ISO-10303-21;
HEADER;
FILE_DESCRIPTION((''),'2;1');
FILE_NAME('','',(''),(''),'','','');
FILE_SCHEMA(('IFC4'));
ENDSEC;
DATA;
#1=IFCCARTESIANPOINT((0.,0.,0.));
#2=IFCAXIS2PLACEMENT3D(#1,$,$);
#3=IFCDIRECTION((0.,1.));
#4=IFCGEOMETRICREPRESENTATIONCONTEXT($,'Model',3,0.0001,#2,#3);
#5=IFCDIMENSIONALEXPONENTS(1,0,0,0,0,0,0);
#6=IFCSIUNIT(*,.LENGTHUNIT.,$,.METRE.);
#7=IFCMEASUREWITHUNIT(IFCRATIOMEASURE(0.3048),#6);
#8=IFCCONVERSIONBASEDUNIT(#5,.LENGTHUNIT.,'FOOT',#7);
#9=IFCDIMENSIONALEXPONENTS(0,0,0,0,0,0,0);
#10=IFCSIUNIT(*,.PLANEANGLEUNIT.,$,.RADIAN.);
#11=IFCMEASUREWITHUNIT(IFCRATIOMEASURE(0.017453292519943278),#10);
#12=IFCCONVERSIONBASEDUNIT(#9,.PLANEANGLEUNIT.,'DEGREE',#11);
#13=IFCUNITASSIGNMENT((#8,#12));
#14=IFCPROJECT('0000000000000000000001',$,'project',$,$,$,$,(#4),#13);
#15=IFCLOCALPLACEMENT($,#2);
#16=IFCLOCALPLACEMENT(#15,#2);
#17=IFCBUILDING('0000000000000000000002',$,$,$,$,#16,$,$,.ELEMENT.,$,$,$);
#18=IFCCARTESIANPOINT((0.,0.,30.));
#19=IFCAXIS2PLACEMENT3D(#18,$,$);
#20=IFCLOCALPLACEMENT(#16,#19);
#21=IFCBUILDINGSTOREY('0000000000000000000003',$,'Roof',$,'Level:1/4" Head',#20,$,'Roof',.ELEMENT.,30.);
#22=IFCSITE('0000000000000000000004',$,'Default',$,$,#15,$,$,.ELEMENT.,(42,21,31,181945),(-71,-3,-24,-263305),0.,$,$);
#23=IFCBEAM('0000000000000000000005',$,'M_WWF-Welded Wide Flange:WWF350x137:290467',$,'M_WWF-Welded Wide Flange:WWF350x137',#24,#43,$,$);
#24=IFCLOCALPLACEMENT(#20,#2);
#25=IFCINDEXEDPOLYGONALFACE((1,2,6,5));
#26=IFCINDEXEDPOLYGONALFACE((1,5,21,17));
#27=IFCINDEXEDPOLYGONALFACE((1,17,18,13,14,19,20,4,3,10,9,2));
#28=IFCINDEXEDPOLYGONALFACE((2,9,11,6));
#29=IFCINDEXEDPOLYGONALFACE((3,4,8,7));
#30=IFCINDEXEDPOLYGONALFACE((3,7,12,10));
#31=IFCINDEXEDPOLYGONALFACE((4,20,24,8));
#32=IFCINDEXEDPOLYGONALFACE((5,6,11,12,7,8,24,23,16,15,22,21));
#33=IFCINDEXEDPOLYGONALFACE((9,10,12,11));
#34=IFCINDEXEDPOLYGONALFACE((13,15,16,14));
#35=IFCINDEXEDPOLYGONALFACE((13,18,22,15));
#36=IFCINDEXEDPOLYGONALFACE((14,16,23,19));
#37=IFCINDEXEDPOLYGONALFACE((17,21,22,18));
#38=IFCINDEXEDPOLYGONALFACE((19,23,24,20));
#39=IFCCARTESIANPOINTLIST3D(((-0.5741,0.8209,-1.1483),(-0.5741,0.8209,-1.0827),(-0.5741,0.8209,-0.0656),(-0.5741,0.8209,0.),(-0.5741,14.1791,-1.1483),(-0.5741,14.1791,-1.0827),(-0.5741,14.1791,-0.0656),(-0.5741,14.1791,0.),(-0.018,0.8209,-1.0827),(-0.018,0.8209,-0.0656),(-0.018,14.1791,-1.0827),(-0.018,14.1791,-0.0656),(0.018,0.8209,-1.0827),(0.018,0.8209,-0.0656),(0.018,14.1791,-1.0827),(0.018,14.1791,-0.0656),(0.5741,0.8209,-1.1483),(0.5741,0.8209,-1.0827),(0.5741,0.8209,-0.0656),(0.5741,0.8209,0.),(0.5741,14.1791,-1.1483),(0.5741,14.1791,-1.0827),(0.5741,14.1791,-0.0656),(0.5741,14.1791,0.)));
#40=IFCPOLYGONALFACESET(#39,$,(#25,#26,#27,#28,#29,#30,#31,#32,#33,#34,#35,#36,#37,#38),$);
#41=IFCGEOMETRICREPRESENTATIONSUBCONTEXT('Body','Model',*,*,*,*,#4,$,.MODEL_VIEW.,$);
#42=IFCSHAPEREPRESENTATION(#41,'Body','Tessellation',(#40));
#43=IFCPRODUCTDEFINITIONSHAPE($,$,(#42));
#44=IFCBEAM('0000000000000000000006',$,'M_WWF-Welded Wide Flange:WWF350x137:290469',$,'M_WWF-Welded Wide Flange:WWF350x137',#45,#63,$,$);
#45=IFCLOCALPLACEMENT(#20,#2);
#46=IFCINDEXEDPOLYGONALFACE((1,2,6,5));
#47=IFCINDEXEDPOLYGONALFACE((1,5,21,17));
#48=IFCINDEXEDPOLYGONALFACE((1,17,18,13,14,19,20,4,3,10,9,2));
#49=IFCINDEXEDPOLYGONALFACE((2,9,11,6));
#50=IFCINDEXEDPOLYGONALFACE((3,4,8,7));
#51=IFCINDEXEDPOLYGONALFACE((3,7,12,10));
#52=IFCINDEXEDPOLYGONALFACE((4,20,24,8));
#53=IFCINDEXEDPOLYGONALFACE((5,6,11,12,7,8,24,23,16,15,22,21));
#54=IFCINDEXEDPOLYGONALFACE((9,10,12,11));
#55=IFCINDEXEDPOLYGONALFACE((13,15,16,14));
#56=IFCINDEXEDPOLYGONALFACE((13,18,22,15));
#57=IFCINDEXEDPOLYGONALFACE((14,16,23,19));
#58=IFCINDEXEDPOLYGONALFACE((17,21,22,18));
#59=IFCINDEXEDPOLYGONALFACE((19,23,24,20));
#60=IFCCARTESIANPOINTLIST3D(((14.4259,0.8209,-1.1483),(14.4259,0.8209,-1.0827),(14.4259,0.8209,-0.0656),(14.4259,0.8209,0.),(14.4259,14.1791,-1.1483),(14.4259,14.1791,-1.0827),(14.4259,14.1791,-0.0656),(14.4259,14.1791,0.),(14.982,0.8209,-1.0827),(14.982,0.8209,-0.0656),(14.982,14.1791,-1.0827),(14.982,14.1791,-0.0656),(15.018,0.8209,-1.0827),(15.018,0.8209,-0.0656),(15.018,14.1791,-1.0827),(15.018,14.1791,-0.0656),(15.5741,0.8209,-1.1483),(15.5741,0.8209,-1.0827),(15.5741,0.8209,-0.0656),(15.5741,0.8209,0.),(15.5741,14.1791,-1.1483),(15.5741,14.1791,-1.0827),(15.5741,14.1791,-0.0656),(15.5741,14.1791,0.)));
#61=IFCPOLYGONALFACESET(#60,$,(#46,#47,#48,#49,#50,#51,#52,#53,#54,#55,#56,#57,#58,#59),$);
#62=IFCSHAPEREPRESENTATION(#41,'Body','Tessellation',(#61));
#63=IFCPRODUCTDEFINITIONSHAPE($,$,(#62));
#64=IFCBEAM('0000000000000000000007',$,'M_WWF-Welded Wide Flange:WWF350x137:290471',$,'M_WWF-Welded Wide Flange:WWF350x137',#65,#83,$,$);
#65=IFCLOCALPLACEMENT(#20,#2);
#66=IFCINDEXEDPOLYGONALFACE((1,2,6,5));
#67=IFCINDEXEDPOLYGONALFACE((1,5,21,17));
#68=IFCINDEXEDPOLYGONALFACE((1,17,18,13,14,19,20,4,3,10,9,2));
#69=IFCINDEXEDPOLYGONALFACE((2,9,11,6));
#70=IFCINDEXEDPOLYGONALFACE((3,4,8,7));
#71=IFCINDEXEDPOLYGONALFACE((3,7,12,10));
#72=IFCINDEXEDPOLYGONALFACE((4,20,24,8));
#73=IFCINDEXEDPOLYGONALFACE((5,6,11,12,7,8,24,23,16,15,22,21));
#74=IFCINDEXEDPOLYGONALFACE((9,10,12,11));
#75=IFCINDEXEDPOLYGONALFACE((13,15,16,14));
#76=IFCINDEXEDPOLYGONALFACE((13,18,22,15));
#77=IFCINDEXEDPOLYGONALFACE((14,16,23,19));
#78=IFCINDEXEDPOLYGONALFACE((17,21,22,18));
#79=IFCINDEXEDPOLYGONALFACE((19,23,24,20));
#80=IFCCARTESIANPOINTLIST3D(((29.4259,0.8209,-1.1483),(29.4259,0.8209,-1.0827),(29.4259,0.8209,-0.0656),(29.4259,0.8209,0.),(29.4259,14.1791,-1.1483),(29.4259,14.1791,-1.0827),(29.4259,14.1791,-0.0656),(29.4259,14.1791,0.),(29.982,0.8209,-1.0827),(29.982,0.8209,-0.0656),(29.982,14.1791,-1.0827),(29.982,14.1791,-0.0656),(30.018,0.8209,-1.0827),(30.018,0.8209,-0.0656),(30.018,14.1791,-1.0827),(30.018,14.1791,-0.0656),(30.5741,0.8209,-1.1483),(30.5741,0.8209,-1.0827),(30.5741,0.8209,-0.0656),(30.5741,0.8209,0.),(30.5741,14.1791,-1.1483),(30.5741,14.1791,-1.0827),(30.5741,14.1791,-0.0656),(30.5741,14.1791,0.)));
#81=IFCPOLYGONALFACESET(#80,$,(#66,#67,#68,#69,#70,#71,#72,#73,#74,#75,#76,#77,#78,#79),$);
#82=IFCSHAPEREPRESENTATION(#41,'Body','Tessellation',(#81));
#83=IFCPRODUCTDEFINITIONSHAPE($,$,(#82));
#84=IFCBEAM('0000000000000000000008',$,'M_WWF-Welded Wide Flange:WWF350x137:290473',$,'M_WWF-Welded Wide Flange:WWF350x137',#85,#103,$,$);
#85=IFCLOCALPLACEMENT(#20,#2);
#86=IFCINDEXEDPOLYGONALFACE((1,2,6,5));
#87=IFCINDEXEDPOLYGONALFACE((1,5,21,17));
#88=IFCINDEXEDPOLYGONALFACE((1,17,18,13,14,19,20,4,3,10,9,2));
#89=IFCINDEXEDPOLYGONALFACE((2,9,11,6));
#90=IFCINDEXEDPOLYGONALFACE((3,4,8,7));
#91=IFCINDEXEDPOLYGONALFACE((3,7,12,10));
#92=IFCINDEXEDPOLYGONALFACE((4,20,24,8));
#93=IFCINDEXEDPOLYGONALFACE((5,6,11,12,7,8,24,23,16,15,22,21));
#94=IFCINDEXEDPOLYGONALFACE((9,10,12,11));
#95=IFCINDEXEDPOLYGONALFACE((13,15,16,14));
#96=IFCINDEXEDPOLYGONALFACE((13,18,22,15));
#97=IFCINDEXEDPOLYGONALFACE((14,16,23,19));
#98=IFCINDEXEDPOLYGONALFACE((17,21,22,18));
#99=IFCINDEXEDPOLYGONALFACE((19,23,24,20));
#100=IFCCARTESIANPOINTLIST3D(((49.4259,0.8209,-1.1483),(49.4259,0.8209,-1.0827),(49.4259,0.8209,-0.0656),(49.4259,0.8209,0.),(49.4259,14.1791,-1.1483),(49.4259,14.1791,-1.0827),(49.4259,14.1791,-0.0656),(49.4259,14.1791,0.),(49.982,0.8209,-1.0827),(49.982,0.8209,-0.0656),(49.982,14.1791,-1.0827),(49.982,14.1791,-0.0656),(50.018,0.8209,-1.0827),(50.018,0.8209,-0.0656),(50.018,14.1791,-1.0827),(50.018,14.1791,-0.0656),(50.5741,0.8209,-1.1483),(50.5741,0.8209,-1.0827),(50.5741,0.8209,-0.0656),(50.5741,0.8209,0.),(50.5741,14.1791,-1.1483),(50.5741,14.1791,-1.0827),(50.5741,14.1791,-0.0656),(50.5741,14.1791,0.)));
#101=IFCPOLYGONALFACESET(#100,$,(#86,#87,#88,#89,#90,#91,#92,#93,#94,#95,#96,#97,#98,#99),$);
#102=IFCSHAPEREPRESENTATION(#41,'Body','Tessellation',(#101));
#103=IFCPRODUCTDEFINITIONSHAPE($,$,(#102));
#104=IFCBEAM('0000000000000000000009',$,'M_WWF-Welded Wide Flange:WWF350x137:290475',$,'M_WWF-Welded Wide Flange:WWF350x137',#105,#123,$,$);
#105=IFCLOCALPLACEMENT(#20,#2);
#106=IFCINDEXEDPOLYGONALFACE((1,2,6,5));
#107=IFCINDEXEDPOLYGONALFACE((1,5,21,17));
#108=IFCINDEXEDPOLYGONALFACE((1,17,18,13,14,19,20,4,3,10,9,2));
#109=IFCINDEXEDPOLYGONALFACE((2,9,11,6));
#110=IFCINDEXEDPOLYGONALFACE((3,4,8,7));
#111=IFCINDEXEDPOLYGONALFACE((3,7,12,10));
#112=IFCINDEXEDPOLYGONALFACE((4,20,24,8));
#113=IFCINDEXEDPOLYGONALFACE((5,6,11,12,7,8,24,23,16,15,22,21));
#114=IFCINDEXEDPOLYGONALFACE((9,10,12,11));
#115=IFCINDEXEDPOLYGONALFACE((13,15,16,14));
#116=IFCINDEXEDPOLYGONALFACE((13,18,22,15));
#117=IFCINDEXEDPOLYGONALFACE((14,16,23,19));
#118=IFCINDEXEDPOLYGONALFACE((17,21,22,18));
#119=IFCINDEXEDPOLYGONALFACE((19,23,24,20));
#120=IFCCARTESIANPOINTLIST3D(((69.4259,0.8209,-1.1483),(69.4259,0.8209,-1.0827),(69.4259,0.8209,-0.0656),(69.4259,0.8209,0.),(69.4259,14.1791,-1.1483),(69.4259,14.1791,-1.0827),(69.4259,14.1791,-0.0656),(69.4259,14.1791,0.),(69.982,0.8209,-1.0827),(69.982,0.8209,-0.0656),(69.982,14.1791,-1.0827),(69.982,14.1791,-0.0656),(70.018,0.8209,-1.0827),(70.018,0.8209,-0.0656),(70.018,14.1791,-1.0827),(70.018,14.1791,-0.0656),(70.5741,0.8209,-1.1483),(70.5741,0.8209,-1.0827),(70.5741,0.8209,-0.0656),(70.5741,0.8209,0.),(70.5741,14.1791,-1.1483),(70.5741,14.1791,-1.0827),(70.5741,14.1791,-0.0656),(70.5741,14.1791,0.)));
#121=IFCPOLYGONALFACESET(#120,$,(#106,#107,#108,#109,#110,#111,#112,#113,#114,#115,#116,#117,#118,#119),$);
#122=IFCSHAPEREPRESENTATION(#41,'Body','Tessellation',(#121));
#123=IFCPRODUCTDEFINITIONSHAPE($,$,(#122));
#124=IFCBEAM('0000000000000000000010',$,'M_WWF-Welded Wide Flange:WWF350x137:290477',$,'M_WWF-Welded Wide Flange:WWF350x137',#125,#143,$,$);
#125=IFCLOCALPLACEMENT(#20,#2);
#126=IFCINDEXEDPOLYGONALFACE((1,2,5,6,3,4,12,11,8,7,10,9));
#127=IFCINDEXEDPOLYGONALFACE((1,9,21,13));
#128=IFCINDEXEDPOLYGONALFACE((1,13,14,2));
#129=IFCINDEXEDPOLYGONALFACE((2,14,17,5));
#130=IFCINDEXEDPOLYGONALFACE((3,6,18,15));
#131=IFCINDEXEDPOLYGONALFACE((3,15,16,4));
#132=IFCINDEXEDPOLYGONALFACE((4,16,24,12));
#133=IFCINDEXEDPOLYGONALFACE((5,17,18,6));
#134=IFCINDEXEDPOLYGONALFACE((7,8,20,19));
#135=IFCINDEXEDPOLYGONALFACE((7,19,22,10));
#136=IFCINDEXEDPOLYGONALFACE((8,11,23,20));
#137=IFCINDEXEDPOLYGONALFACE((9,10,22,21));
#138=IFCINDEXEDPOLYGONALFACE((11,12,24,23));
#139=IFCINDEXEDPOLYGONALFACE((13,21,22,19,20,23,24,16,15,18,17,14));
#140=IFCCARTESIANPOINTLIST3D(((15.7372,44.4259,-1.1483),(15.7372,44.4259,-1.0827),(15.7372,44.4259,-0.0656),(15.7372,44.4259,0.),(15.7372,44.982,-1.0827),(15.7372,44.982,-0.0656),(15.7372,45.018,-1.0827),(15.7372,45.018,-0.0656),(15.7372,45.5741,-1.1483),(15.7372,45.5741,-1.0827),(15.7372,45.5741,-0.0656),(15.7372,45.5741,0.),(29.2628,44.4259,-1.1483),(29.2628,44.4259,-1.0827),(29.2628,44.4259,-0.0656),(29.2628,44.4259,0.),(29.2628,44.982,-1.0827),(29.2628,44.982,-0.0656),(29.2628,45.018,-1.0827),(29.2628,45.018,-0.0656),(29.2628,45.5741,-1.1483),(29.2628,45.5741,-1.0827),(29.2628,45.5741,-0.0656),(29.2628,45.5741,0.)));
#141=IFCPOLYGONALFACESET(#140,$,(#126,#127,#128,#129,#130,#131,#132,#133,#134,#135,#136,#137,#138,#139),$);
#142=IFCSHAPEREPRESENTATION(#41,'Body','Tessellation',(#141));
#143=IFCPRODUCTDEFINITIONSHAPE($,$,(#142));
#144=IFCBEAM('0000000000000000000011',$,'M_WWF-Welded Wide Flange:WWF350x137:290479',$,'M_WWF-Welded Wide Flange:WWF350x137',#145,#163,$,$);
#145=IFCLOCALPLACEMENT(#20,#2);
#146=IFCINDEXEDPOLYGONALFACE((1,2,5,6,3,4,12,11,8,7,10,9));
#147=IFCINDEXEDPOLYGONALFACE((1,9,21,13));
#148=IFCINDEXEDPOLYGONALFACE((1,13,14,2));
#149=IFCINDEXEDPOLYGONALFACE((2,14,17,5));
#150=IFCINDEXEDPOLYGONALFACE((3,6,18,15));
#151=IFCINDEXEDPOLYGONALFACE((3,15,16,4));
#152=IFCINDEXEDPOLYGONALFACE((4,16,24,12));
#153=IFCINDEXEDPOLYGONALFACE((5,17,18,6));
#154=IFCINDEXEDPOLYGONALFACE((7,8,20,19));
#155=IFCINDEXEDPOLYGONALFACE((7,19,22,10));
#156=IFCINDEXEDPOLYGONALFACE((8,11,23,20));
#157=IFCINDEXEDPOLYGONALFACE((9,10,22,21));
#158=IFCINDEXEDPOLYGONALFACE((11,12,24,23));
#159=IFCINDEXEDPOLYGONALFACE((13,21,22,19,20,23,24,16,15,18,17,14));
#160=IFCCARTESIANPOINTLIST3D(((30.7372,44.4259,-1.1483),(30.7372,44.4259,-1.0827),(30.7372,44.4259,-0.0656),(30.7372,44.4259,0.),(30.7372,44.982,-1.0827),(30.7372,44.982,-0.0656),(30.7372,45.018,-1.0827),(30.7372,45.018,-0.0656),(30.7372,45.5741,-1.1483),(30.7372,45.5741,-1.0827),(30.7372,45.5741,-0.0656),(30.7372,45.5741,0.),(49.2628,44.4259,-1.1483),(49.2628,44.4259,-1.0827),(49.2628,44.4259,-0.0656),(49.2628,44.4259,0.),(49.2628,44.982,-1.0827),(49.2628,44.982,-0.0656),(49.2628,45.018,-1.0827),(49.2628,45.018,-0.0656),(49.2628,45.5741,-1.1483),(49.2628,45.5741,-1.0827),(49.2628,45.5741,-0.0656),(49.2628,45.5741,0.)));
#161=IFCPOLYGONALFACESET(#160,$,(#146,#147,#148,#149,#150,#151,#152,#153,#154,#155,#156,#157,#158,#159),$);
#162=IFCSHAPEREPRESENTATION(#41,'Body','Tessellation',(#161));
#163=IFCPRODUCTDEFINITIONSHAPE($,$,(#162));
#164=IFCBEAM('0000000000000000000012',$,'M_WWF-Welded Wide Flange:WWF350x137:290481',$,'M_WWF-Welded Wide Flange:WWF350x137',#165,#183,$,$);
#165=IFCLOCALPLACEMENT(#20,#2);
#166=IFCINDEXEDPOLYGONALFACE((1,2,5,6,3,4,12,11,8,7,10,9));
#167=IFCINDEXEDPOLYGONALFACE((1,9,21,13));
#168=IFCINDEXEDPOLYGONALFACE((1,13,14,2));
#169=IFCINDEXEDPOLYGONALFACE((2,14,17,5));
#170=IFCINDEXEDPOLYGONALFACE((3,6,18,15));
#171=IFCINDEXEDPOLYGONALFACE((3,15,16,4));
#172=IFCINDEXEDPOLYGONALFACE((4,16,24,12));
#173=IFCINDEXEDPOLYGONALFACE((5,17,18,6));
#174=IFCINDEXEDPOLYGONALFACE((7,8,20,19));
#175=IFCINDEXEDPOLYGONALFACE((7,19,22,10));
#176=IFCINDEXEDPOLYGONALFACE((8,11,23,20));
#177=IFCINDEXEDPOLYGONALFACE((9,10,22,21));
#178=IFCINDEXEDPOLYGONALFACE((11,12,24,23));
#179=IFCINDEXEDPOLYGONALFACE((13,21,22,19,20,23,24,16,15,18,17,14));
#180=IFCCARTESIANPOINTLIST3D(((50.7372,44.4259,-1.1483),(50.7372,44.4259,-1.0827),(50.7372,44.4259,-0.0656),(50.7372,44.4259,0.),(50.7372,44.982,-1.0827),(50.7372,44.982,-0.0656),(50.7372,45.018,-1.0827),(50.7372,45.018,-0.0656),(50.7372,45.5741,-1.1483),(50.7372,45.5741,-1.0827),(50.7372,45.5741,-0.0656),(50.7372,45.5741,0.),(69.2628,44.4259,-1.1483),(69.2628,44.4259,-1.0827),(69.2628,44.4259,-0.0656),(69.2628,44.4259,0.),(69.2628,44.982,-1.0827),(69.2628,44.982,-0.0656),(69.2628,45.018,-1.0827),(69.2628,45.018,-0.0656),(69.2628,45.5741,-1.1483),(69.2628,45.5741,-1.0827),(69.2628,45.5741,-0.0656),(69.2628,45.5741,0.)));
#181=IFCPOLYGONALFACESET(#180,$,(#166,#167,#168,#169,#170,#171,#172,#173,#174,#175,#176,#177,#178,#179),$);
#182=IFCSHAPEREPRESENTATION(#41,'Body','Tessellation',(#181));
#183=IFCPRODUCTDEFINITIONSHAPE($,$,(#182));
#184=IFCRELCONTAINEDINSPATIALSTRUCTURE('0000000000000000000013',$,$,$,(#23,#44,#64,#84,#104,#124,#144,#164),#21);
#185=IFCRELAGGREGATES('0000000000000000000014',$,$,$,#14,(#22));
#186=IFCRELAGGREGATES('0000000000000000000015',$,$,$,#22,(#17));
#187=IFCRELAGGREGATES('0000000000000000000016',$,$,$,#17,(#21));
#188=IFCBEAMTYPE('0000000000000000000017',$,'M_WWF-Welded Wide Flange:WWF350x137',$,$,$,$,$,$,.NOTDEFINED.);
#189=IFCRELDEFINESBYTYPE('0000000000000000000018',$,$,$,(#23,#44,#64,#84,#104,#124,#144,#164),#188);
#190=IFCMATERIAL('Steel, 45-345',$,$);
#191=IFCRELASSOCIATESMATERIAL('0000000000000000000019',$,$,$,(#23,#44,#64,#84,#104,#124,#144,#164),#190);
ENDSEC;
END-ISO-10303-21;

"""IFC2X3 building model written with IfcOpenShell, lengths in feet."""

from ifc_helpers import new_model, entity, si_unit, converted_unit, direction, frame, frame_2d, origin, place, context, subcontext, project, spatial, i_section, extrude, material, type_object, element, save


model = new_model("IFC2X3")

# Units and contexts
model_context = context("Model", 3, precision=0.0001, world=origin(), true_north=direction((0.0, 1.0)))
body_context = subcontext(model_context, "Body", "Model", "MODEL_VIEW")
ifc_project = project(units=[converted_unit("LENGTHUNIT", "FOOT", entity("IfcRatioMeasure", 0.3048), si_unit("LENGTHUNIT", "METRE"), dimensions=[1, 0, 0, 0, 0, 0, 0]), converted_unit("PLANEANGLEUNIT", "DEGREE", entity("IfcRatioMeasure", 0.017453292519943278), si_unit("PLANEANGLEUNIT", "RADIAN"), dimensions=[0, 0, 0, 0, 0, 0, 0])], contexts=[model_context])

# Site, building, storey
site_placement = place(None, origin())
site = spatial("IfcSite", under=ifc_project, at=site_placement, Name="Default", CompositionType="ELEMENT", RefLatitude=(42, 21, 31, 181945), RefLongitude=(-71, -3, -24, -263305), RefElevation=0.0)
building_placement = place(site_placement, origin())
building = spatial("IfcBuilding", under=site, at=building_placement, CompositionType="ELEMENT")
storey_placement = place(building_placement, frame((0.0, 0.0, 30.0)))
storey = spatial("IfcBuildingStorey", under=building, at=storey_placement, Name="Roof", ObjectType="Level:1/4\" Head", LongName="Roof", CompositionType="ELEMENT", Elevation=30.0)

# Beams
ifc_material = material(Name="Steel, 45-345")
beam_type = type_object("IfcBeamType", Name="M_WWF-Welded Wide Flange:WWF350x137", PredefinedType="NOTDEFINED")
beam_1_placement = place(storey_placement, frame((0.0, 0.0, 0.0), z_axis=(0.0, 0.0, 1.0), x_axis=(0.0, 1.0, 0.0)))
element("IfcBeam", 1, at=beam_1_placement, inside=storey, type_object=beam_type, material=ifc_material, Name="M_WWF-Welded Wide Flange:WWF350x137:290467", ObjectType="M_WWF-Welded Wide Flange:WWF350x137", context=body_context, shape_type="SweptSolid", body=[
    extrude(i_section(OverallWidth=1.1483, OverallDepth=1.1483, WebThickness=0.0361, FlangeThickness=0.0656, at=frame_2d((0.0, 0.0), x_axis=(0.0, 1.0))), frame((0.8209, 0.0, -0.5741), z_axis=(1.0, 0.0, 0.0), x_axis=(0.0, 0.0, -1.0)), (0.0, 0.0, 1.0), 13.3583),
])
beam_2_placement = place(storey_placement, frame((15.0, 0.0, 0.0), z_axis=(0.0, 0.0, 1.0), x_axis=(0.0, 1.0, 0.0)))
element("IfcBeam", 2, at=beam_2_placement, inside=storey, type_object=beam_type, material=ifc_material, Name="M_WWF-Welded Wide Flange:WWF350x137:290469", ObjectType="M_WWF-Welded Wide Flange:WWF350x137", context=body_context, shape_type="SweptSolid", body=[
    extrude(i_section(OverallWidth=1.1483, OverallDepth=1.1483, WebThickness=0.0361, FlangeThickness=0.0656, at=frame_2d((0.0, 0.0), x_axis=(0.0, 1.0))), frame((0.8209, 0.0, -0.5741), z_axis=(1.0, 0.0, 0.0), x_axis=(0.0, 0.0, -1.0)), (0.0, 0.0, 1.0), 13.3583),
])
beam_3_placement = place(storey_placement, frame((30.0, 0.0, 0.0), z_axis=(0.0, 0.0, 1.0), x_axis=(0.0, 1.0, 0.0)))
element("IfcBeam", 3, at=beam_3_placement, inside=storey, type_object=beam_type, material=ifc_material, Name="M_WWF-Welded Wide Flange:WWF350x137:290471", ObjectType="M_WWF-Welded Wide Flange:WWF350x137", context=body_context, shape_type="SweptSolid", body=[
    extrude(i_section(OverallWidth=1.1483, OverallDepth=1.1483, WebThickness=0.0361, FlangeThickness=0.0656, at=frame_2d((0.0, 0.0), x_axis=(0.0, 1.0))), frame((0.8209, 0.0, -0.5741), z_axis=(1.0, 0.0, 0.0), x_axis=(0.0, 0.0, -1.0)), (0.0, 0.0, 1.0), 13.3583),
])
beam_4_placement = place(storey_placement, frame((50.0, 0.0, 0.0), z_axis=(0.0, 0.0, 1.0), x_axis=(0.0, 1.0, 0.0)))
element("IfcBeam", 4, at=beam_4_placement, inside=storey, type_object=beam_type, material=ifc_material, Name="M_WWF-Welded Wide Flange:WWF350x137:290473", ObjectType="M_WWF-Welded Wide Flange:WWF350x137", context=body_context, shape_type="SweptSolid", body=[
    extrude(i_section(OverallWidth=1.1483, OverallDepth=1.1483, WebThickness=0.0361, FlangeThickness=0.0656, at=frame_2d((0.0, 0.0), x_axis=(0.0, 1.0))), frame((0.8209, 0.0, -0.5741), z_axis=(1.0, 0.0, 0.0), x_axis=(0.0, 0.0, -1.0)), (0.0, 0.0, 1.0), 13.3583),
])
beam_5_placement = place(storey_placement, frame((70.0, 0.0, 0.0), z_axis=(0.0, 0.0, 1.0), x_axis=(0.0, 1.0, 0.0)))
element("IfcBeam", 5, at=beam_5_placement, inside=storey, type_object=beam_type, material=ifc_material, Name="M_WWF-Welded Wide Flange:WWF350x137:290475", ObjectType="M_WWF-Welded Wide Flange:WWF350x137", context=body_context, shape_type="SweptSolid", body=[
    extrude(i_section(OverallWidth=1.1483, OverallDepth=1.1483, WebThickness=0.0361, FlangeThickness=0.0656, at=frame_2d((0.0, 0.0), x_axis=(0.0, 1.0))), frame((0.8209, 0.0, -0.5741), z_axis=(1.0, 0.0, 0.0), x_axis=(0.0, 0.0, -1.0)), (0.0, 0.0, 1.0), 13.3583),
])
beam_6_placement = place(storey_placement, frame((15.0, 45.0, 0.0)))
element("IfcBeam", 6, at=beam_6_placement, inside=storey, type_object=beam_type, material=ifc_material, Name="M_WWF-Welded Wide Flange:WWF350x137:290477", ObjectType="M_WWF-Welded Wide Flange:WWF350x137", context=body_context, shape_type="SweptSolid", body=[
    extrude(i_section(OverallWidth=1.1483, OverallDepth=1.1483, WebThickness=0.0361, FlangeThickness=0.0656, at=frame_2d((0.0, 0.0), x_axis=(0.0, 1.0))), frame((0.7372, 0.0, -0.5741), z_axis=(1.0, 0.0, 0.0), x_axis=(0.0, 0.0, -1.0)), (0.0, 0.0, 1.0), 13.5256),
])
beam_7_placement = place(storey_placement, frame((30.0, 45.0, 0.0)))
element("IfcBeam", 7, at=beam_7_placement, inside=storey, type_object=beam_type, material=ifc_material, Name="M_WWF-Welded Wide Flange:WWF350x137:290479", ObjectType="M_WWF-Welded Wide Flange:WWF350x137", context=body_context, shape_type="SweptSolid", body=[
    extrude(i_section(OverallWidth=1.1483, OverallDepth=1.1483, WebThickness=0.0361, FlangeThickness=0.0656, at=frame_2d((0.0, 0.0), x_axis=(0.0, 1.0))), frame((0.7372, 0.0, -0.5741), z_axis=(1.0, 0.0, 0.0), x_axis=(0.0, 0.0, -1.0)), (0.0, 0.0, 1.0), 18.5256),
])
beam_8_placement = place(storey_placement, frame((50.0, 45.0, 0.0)))
element("IfcBeam", 8, at=beam_8_placement, inside=storey, type_object=beam_type, material=ifc_material, Name="M_WWF-Welded Wide Flange:WWF350x137:290481", ObjectType="M_WWF-Welded Wide Flange:WWF350x137", context=body_context, shape_type="SweptSolid", body=[
    extrude(i_section(OverallWidth=1.1483, OverallDepth=1.1483, WebThickness=0.0361, FlangeThickness=0.0656, at=frame_2d((0.0, 0.0), x_axis=(0.0, 1.0))), frame((0.7372, 0.0, -0.5741), z_axis=(1.0, 0.0, 0.0), x_axis=(0.0, 0.0, -1.0)), (0.0, 0.0, 1.0), 18.5256),
])

save(model, "model.ifc")
